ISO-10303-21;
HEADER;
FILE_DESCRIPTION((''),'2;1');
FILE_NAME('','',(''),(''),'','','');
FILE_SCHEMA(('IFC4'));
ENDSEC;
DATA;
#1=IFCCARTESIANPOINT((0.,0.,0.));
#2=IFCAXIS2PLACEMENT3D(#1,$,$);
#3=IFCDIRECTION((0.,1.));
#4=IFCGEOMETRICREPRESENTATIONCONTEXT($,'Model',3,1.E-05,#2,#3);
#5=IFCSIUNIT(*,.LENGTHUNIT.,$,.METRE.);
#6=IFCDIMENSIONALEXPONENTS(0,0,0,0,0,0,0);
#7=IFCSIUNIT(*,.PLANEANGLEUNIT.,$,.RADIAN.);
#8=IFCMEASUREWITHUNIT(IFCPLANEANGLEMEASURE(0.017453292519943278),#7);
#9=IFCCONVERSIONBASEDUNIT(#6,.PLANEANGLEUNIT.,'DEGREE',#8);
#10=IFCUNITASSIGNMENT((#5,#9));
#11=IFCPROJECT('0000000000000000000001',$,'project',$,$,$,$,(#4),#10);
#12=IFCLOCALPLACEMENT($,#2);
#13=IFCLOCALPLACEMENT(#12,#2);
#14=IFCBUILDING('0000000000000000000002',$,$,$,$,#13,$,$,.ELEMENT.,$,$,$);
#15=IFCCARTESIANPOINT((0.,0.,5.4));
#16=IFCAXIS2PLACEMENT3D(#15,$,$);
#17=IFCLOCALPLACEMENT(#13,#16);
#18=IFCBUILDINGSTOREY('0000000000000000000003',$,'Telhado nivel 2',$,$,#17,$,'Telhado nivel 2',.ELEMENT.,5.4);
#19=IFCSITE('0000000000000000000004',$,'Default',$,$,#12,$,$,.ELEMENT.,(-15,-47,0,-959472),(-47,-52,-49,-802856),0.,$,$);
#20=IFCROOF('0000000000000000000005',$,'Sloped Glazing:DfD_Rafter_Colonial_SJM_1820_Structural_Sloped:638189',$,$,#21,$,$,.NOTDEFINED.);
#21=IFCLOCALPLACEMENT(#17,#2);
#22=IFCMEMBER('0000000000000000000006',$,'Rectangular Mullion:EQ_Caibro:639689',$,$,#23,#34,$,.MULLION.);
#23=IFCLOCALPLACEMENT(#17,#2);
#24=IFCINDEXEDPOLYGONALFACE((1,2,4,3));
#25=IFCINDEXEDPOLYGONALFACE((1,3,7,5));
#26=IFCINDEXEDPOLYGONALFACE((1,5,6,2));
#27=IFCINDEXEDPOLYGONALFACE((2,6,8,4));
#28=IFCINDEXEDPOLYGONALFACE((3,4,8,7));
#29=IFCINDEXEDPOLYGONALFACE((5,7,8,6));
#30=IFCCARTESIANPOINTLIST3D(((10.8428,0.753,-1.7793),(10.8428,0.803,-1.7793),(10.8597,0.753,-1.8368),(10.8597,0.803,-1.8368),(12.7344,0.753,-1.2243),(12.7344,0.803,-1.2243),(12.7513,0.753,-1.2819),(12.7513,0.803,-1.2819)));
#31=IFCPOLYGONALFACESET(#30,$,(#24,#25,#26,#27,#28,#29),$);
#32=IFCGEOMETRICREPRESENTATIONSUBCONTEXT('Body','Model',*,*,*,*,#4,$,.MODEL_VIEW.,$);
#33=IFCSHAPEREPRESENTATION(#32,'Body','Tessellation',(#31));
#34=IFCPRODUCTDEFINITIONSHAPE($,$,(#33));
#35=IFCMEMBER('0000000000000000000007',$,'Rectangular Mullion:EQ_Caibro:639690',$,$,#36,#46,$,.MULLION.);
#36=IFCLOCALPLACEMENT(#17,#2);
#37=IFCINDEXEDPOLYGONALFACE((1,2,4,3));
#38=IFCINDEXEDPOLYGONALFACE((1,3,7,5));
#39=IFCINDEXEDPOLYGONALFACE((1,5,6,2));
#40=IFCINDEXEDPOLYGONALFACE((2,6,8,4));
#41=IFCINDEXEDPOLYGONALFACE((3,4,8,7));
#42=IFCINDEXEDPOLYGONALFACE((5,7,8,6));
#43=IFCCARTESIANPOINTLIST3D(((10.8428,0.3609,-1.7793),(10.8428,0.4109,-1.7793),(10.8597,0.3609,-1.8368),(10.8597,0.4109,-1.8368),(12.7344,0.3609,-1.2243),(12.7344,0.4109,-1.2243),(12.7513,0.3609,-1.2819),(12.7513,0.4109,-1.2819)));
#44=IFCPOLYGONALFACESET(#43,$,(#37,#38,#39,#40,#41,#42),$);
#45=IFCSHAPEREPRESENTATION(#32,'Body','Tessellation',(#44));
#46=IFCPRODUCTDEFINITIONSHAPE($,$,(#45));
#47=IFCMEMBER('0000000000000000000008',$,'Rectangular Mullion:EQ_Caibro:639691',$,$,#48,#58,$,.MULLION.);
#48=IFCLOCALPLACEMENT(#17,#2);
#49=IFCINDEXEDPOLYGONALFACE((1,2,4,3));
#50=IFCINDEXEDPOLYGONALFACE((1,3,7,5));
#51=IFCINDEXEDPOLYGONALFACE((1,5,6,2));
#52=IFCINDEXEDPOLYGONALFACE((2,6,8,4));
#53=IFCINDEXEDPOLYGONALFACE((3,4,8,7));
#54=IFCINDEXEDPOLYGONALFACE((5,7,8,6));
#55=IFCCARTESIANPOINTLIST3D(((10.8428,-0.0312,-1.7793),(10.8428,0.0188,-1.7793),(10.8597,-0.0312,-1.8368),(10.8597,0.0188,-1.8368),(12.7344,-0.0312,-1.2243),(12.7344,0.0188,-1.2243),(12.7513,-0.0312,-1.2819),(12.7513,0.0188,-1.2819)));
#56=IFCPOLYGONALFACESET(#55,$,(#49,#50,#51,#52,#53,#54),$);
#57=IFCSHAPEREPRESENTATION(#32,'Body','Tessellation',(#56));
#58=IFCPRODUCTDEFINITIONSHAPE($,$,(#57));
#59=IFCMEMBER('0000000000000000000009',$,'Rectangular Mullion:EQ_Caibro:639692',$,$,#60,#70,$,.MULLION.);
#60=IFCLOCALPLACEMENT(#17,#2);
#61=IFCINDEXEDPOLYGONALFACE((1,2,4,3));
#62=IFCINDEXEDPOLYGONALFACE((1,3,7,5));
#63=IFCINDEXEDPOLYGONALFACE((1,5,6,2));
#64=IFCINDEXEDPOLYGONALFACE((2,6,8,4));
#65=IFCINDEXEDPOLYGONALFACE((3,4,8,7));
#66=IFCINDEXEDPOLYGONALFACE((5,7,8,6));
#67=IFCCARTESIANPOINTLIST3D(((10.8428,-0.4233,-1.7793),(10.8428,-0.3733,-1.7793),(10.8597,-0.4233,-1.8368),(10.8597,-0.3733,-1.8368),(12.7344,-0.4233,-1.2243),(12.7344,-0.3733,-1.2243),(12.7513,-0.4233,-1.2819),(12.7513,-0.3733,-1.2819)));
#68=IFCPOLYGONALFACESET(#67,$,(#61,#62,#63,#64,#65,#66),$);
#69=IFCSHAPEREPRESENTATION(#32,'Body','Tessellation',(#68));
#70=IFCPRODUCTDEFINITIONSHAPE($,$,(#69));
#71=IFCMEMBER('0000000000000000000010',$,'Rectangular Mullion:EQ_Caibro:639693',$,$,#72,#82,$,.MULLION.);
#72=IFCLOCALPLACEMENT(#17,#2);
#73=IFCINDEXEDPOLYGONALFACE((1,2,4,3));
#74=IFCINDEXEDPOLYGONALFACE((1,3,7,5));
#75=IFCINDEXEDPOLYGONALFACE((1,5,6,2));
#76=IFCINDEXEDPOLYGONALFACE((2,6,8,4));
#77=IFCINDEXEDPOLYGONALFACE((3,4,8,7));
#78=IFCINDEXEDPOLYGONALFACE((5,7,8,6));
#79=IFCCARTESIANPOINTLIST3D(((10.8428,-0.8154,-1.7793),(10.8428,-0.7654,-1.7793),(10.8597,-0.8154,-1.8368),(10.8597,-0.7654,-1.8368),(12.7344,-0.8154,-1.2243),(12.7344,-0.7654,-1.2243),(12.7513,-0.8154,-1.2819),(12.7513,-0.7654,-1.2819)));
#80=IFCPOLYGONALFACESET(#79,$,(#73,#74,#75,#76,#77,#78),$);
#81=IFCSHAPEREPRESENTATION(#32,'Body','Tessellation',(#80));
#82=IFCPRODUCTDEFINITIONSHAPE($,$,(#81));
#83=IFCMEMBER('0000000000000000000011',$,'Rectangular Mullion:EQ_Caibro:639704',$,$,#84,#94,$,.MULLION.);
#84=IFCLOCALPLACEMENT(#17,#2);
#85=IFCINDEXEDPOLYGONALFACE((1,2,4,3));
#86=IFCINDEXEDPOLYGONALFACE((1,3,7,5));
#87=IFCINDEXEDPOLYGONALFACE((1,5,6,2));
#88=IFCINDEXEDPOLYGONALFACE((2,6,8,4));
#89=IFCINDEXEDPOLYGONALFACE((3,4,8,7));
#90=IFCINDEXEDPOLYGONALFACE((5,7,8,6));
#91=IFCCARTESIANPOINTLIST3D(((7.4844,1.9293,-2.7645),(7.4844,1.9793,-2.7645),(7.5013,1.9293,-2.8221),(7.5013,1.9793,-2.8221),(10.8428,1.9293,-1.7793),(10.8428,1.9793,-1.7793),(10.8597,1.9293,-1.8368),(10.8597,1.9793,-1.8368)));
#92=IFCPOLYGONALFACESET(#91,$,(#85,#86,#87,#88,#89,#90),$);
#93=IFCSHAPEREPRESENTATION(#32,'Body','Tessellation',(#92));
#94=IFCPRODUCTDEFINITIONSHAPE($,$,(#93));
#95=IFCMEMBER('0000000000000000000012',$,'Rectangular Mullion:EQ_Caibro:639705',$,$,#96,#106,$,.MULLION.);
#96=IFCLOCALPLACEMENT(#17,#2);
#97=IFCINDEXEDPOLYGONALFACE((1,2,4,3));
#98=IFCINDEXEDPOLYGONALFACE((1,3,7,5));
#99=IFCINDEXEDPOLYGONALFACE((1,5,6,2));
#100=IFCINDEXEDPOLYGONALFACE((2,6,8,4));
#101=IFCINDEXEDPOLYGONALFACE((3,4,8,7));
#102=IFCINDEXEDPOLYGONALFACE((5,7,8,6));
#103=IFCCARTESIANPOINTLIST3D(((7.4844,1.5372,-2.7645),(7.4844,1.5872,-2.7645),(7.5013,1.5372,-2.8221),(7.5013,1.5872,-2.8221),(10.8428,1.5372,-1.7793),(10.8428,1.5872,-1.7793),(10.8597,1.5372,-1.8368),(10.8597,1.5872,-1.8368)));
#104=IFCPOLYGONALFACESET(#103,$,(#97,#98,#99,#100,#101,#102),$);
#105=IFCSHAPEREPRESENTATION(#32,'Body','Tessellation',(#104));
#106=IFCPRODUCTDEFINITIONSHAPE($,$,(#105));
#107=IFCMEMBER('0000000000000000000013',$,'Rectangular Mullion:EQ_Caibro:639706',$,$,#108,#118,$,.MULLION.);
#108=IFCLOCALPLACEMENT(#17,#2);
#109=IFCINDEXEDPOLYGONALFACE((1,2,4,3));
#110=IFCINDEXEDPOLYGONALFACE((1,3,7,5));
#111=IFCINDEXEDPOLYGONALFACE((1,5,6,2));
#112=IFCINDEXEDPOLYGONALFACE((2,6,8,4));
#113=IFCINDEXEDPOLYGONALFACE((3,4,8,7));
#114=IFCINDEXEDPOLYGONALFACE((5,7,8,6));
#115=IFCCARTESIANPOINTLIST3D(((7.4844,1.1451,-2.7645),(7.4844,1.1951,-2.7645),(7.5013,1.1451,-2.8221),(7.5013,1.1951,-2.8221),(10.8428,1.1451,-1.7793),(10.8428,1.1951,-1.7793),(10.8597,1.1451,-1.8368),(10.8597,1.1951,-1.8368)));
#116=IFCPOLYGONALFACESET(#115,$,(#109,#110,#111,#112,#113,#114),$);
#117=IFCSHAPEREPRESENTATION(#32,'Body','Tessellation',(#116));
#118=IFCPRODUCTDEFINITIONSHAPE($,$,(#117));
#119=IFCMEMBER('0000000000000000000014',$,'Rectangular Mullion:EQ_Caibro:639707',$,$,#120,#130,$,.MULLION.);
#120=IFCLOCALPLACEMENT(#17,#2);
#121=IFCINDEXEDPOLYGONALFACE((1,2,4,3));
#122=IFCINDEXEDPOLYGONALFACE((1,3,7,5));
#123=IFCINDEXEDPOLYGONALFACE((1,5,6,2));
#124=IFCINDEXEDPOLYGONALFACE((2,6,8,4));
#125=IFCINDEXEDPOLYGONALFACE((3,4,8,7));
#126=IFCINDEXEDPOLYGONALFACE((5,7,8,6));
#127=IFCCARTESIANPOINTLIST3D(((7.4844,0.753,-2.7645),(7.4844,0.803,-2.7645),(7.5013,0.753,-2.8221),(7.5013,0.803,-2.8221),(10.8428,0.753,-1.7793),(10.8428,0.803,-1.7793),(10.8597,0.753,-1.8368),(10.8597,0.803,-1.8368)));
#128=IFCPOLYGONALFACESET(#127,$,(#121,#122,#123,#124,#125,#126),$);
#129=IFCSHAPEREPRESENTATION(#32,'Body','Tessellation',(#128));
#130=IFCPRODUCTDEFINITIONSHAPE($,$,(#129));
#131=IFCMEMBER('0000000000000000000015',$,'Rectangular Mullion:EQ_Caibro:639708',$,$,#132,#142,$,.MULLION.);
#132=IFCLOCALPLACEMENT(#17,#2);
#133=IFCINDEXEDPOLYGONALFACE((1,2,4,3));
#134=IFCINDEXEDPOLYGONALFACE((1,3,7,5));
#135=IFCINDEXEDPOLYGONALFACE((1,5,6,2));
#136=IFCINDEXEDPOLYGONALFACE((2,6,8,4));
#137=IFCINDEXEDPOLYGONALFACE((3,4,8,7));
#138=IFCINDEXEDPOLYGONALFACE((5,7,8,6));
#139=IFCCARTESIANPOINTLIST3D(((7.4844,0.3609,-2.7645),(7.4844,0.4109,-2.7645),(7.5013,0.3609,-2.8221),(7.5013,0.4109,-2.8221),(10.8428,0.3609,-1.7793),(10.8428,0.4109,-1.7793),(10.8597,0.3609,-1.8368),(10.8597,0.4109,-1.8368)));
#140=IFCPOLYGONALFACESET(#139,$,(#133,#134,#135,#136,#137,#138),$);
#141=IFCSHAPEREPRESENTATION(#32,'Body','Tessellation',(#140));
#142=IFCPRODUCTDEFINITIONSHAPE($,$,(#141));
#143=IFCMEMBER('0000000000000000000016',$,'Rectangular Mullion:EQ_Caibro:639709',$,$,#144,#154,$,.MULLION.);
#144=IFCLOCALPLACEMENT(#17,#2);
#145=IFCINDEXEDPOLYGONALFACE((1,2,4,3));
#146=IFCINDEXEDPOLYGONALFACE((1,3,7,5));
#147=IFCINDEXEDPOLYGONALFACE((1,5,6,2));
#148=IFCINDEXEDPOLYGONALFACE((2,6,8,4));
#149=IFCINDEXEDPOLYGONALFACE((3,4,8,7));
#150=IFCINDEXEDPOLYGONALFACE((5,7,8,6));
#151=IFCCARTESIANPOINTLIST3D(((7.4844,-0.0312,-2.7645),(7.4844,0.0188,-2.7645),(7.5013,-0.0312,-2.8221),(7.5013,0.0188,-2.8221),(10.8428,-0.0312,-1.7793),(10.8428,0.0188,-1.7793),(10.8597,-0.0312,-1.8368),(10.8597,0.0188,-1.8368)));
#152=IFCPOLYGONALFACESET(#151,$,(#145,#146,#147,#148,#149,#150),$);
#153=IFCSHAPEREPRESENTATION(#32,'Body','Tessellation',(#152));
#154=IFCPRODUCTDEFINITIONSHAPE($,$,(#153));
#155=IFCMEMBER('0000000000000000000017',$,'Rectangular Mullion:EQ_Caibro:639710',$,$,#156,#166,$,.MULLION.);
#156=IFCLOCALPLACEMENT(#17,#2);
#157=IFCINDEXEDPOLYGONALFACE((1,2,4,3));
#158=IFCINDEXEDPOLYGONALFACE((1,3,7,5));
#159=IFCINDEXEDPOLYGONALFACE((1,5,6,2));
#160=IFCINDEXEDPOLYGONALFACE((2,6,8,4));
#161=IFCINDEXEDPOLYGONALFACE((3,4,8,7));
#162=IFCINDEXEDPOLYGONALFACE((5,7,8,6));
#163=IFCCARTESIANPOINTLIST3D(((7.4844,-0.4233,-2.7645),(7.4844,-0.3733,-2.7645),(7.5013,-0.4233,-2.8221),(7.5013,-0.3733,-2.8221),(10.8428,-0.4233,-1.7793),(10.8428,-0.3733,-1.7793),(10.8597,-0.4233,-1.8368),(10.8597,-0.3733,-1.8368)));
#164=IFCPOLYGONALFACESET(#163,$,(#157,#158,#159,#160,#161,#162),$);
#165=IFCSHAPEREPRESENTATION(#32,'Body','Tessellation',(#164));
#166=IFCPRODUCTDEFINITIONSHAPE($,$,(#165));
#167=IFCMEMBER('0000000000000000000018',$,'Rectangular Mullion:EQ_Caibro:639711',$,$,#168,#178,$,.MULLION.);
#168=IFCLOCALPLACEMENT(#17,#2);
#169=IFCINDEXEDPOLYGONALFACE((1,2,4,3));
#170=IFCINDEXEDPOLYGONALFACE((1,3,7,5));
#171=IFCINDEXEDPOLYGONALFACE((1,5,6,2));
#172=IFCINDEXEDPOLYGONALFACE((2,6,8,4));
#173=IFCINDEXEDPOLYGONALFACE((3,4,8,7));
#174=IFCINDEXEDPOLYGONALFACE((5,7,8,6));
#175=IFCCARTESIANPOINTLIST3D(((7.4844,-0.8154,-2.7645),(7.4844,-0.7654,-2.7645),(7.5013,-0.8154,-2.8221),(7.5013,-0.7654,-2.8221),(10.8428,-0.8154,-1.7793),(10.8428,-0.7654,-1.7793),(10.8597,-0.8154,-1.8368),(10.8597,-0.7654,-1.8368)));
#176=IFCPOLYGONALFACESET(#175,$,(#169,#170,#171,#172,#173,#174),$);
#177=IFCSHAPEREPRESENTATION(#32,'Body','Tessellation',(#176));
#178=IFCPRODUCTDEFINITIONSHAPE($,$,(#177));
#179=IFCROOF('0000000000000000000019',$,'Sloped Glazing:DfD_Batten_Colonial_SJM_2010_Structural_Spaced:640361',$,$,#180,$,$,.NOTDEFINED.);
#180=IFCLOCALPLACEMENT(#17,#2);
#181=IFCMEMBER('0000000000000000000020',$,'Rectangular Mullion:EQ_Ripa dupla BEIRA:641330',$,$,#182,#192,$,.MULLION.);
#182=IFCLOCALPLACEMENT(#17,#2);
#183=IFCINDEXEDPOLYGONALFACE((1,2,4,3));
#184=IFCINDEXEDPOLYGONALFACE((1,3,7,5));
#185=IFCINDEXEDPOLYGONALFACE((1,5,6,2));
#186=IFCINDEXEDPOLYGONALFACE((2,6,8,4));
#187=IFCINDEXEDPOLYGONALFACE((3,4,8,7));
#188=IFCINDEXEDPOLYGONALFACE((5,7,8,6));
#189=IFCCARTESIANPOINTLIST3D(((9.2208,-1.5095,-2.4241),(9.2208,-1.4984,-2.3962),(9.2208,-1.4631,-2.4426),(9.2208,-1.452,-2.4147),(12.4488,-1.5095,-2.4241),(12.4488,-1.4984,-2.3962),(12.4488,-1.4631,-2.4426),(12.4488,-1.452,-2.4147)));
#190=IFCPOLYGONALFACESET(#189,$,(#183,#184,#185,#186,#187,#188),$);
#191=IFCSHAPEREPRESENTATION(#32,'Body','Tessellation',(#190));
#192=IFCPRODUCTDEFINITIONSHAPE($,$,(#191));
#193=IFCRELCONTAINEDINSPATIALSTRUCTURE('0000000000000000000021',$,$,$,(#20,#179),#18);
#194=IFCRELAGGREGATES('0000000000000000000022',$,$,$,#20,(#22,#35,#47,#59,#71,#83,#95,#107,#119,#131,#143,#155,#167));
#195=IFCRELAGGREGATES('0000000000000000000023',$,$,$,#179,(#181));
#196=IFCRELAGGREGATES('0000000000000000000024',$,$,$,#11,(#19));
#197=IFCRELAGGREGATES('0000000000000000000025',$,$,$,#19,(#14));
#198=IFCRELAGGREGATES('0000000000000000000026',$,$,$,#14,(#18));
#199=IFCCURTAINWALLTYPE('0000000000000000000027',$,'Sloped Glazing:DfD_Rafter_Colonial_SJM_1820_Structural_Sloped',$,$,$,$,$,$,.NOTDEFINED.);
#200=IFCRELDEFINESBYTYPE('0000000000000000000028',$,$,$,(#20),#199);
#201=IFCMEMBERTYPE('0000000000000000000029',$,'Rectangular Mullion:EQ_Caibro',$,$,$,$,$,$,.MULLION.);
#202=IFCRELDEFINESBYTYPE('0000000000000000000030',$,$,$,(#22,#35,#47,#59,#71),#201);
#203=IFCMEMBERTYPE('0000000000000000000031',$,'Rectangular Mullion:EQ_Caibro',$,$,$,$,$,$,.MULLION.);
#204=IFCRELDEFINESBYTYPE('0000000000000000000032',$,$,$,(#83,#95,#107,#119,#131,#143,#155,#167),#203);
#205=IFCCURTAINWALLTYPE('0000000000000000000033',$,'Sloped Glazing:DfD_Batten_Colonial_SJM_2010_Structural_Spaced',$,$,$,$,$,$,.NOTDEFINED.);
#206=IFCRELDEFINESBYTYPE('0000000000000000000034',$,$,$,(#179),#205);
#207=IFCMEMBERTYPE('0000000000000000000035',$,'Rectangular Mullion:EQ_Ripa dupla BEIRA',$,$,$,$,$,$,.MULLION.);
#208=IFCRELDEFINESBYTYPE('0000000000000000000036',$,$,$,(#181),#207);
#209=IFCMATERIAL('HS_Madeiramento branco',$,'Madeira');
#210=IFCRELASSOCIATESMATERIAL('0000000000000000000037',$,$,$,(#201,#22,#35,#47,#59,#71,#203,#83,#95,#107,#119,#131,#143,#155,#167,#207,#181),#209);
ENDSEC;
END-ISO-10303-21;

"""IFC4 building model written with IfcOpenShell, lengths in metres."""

from ifc_helpers import new_model, entity, si_unit, converted_unit, direction, frame, origin, place, context, subcontext, project, spatial, indexed_curve, outline, extrude, source, transform, mapped, material, type_object, type_shapes, element, aggregate, save


model = new_model("IFC4")

# Units and contexts
model_context = context("Model", 3, precision=1e-05, world=origin(), true_north=direction((0.0, 1.0)))
body_context = subcontext(model_context, "Body", "Model", "MODEL_VIEW")
ifc_project = project(units=[si_unit("LENGTHUNIT", "METRE"), converted_unit("PLANEANGLEUNIT", "DEGREE", entity("IfcPlaneAngleMeasure", 0.017453292519943278), si_unit("PLANEANGLEUNIT", "RADIAN"), dimensions=[0, 0, 0, 0, 0, 0, 0])], contexts=[model_context])

# Site, building, storey
site_placement = place(None, origin())
site = spatial("IfcSite", under=ifc_project, at=site_placement, Name="Default", CompositionType="ELEMENT", RefLatitude=(-15, -47, 0, -959472), RefLongitude=(-47, -52, -49, -802856), RefElevation=0.0)
building_placement = place(site_placement, origin())
building = spatial("IfcBuilding", under=site, at=building_placement, CompositionType="ELEMENT")
storey_placement = place(building_placement, frame((0.0, 0.0, 5.4)))
storey = spatial("IfcBuildingStorey", under=building, at=storey_placement, Name="Telhado nivel 2", LongName="Telhado nivel 2", CompositionType="ELEMENT", Elevation=5.4)

# Roofs, members
curtain_wall_type_1 = type_object("IfcCurtainWallType", Name="Sloped Glazing:DfD_Rafter_Colonial_SJM_1820_Structural_Sloped", PredefinedType="NOTDEFINED")
ifc_material = material(Name="HS_Madeiramento branco", Category="Madeira")
roof_1_placement = place(storey_placement, frame((0.0, 0.0, -5.4)))
roof_1 = element("IfcRoof", 1, at=roof_1_placement, inside=storey, type_object=curtain_wall_type_1, Name="Sloped Glazing:DfD_Rafter_Colonial_SJM_1820_Structural_Sloped:638189", PredefinedType="NOTDEFINED")
member_type_1 = type_object("IfcMemberType", Name="Rectangular Mullion:EQ_Caibro", PredefinedType="MULLION", material=ifc_material)
shared_shape_1 = source(origin(), body_context, "Body", "SweptSolid", [
    extrude(outline(indexed_curve([(-0.025, -0.03), (0.025, -0.03), (0.025, 0.03), (-0.025, 0.03), (-0.025, -0.03)], self_intersect=False)), frame((0.0, -0.03, -1.9713), z_axis=(0.0, 0.0, 1.0), x_axis=(-1.0, 0.0, 0.0)), (0.0, 0.0, 1.0), 1.9713),
])
type_shapes(member_type_1, [shared_shape_1])
member_1_placement = place(roof_1_placement, frame((12.7513, 0.778, 4.1181), z_axis=(0.95956, 0.0, 0.281504), x_axis=(0.0, -1.0, 0.0)))
member_1 = element("IfcMember", 2, at=member_1_placement, type_object=member_type_1, material=ifc_material, Name="Rectangular Mullion:EQ_Caibro:639689", PredefinedType="MULLION", context=body_context, shape_type="MappedRepresentation", body=[
    mapped(shared_shape_1, transform((0.0, 0.0, 0.0), scale=1.0)),
])
member_2_placement = place(roof_1_placement, frame((12.7513, 0.3859, 4.1181), z_axis=(0.95956, 0.0, 0.281504), x_axis=(0.0, -1.0, 0.0)))
member_2 = element("IfcMember", 3, at=member_2_placement, type_object=member_type_1, material=ifc_material, Name="Rectangular Mullion:EQ_Caibro:639690", PredefinedType="MULLION", context=body_context, shape_type="MappedRepresentation", body=[
    mapped(shared_shape_1, transform((0.0, 0.0, 0.0), scale=1.0)),
])
member_3_placement = place(roof_1_placement, frame((12.7513, -0.0062, 4.1181), z_axis=(0.95956, 0.0, 0.281504), x_axis=(0.0, -1.0, 0.0)))
member_3 = element("IfcMember", 4, at=member_3_placement, type_object=member_type_1, material=ifc_material, Name="Rectangular Mullion:EQ_Caibro:639691", PredefinedType="MULLION", context=body_context, shape_type="MappedRepresentation", body=[
    mapped(shared_shape_1, transform((0.0, 0.0, 0.0), scale=1.0)),
])
member_4_placement = place(roof_1_placement, frame((12.7513, -0.3983, 4.1181), z_axis=(0.95956, 0.0, 0.281504), x_axis=(0.0, -1.0, 0.0)))
member_4 = element("IfcMember", 5, at=member_4_placement, type_object=member_type_1, material=ifc_material, Name="Rectangular Mullion:EQ_Caibro:639692", PredefinedType="MULLION", context=body_context, shape_type="MappedRepresentation", body=[
    mapped(shared_shape_1, transform((0.0, 0.0, 0.0), scale=1.0)),
])
member_5_placement = place(roof_1_placement, frame((12.7513, -0.7904, 4.1181), z_axis=(0.95956, 0.0, 0.281504), x_axis=(0.0, -1.0, 0.0)))
member_5 = element("IfcMember", 6, at=member_5_placement, type_object=member_type_1, material=ifc_material, Name="Rectangular Mullion:EQ_Caibro:639693", PredefinedType="MULLION", context=body_context, shape_type="MappedRepresentation", body=[
    mapped(shared_shape_1, transform((0.0, 0.0, 0.0), scale=1.0)),
])
member_type_2 = type_object("IfcMemberType", Name="Rectangular Mullion:EQ_Caibro", PredefinedType="MULLION", material=ifc_material)
shared_shape_2 = source(origin(), body_context, "Body", "SweptSolid", [
    extrude(outline(indexed_curve([(-0.025, -0.03), (0.025, -0.03), (0.025, 0.03), (-0.025, 0.03), (-0.025, -0.03)], self_intersect=False)), frame((0.0, -0.03, -3.5), z_axis=(0.0, 0.0, 1.0), x_axis=(-1.0, 0.0, 0.0)), (0.0, 0.0, 1.0), 3.5),
])
type_shapes(member_type_2, [shared_shape_2])
member_6_placement = place(roof_1_placement, frame((10.8597, 1.9543, 3.5632), z_axis=(0.95956, 0.0, 0.281504), x_axis=(0.0, -1.0, 0.0)))
member_6 = element("IfcMember", 7, at=member_6_placement, type_object=member_type_2, material=ifc_material, Name="Rectangular Mullion:EQ_Caibro:639704", PredefinedType="MULLION", context=body_context, shape_type="MappedRepresentation", body=[
    mapped(shared_shape_2, transform((0.0, 0.0, 0.0), scale=1.0)),
])
member_7_placement = place(roof_1_placement, frame((10.8597, 1.5622, 3.5632), z_axis=(0.95956, 0.0, 0.281504), x_axis=(0.0, -1.0, 0.0)))
member_7 = element("IfcMember", 8, at=member_7_placement, type_object=member_type_2, material=ifc_material, Name="Rectangular Mullion:EQ_Caibro:639705", PredefinedType="MULLION", context=body_context, shape_type="MappedRepresentation", body=[
    mapped(shared_shape_2, transform((0.0, 0.0, 0.0), scale=1.0)),
])
member_8_placement = place(roof_1_placement, frame((10.8597, 1.1701, 3.5632), z_axis=(0.95956, 0.0, 0.281504), x_axis=(0.0, -1.0, 0.0)))
member_8 = element("IfcMember", 9, at=member_8_placement, type_object=member_type_2, material=ifc_material, Name="Rectangular Mullion:EQ_Caibro:639706", PredefinedType="MULLION", context=body_context, shape_type="MappedRepresentation", body=[
    mapped(shared_shape_2, transform((0.0, 0.0, 0.0), scale=1.0)),
])
member_9_placement = place(roof_1_placement, frame((10.8597, 0.778, 3.5632), z_axis=(0.95956, 0.0, 0.281504), x_axis=(0.0, -1.0, 0.0)))
member_9 = element("IfcMember", 10, at=member_9_placement, type_object=member_type_2, material=ifc_material, Name="Rectangular Mullion:EQ_Caibro:639707", PredefinedType="MULLION", context=body_context, shape_type="MappedRepresentation", body=[
    mapped(shared_shape_2, transform((0.0, 0.0, 0.0), scale=1.0)),
])
member_10_placement = place(roof_1_placement, frame((10.8597, 0.3859, 3.5632), z_axis=(0.95956, 0.0, 0.281504), x_axis=(0.0, -1.0, 0.0)))
member_10 = element("IfcMember", 11, at=member_10_placement, type_object=member_type_2, material=ifc_material, Name="Rectangular Mullion:EQ_Caibro:639708", PredefinedType="MULLION", context=body_context, shape_type="MappedRepresentation", body=[
    mapped(shared_shape_2, transform((0.0, 0.0, 0.0), scale=1.0)),
])
member_11_placement = place(roof_1_placement, frame((10.8597, -0.0062, 3.5632), z_axis=(0.95956, 0.0, 0.281504), x_axis=(0.0, -1.0, 0.0)))
member_11 = element("IfcMember", 12, at=member_11_placement, type_object=member_type_2, material=ifc_material, Name="Rectangular Mullion:EQ_Caibro:639709", PredefinedType="MULLION", context=body_context, shape_type="MappedRepresentation", body=[
    mapped(shared_shape_2, transform((0.0, 0.0, 0.0), scale=1.0)),
])
member_12_placement = place(roof_1_placement, frame((10.8597, -0.3983, 3.5632), z_axis=(0.95956, 0.0, 0.281504), x_axis=(0.0, -1.0, 0.0)))
member_12 = element("IfcMember", 13, at=member_12_placement, type_object=member_type_2, material=ifc_material, Name="Rectangular Mullion:EQ_Caibro:639710", PredefinedType="MULLION", context=body_context, shape_type="MappedRepresentation", body=[
    mapped(shared_shape_2, transform((0.0, 0.0, 0.0), scale=1.0)),
])
member_13_placement = place(roof_1_placement, frame((10.8597, -0.7904, 3.5632), z_axis=(0.95956, 0.0, 0.281504), x_axis=(0.0, -1.0, 0.0)))
member_13 = element("IfcMember", 14, at=member_13_placement, type_object=member_type_2, material=ifc_material, Name="Rectangular Mullion:EQ_Caibro:639711", PredefinedType="MULLION", context=body_context, shape_type="MappedRepresentation", body=[
    mapped(shared_shape_2, transform((0.0, 0.0, 0.0), scale=1.0)),
])
aggregate(roof_1, [member_1, member_2, member_3, member_4, member_5, member_6, member_7, member_8, member_9, member_10, member_11, member_12, member_13])
curtain_wall_type_2 = type_object("IfcCurtainWallType", Name="Sloped Glazing:DfD_Batten_Colonial_SJM_2010_Structural_Spaced", PredefinedType="NOTDEFINED")
roof_2_placement = place(storey_placement, frame((0.0, 0.0, -5.4)))
roof_2 = element("IfcRoof", 15, at=roof_2_placement, inside=storey, type_object=curtain_wall_type_2, Name="Sloped Glazing:DfD_Batten_Colonial_SJM_2010_Structural_Spaced:640361", PredefinedType="NOTDEFINED")
member_type_3 = type_object("IfcMemberType", Name="Rectangular Mullion:EQ_Ripa dupla BEIRA", PredefinedType="MULLION", material=ifc_material)
shared_shape_3 = source(origin(), body_context, "Body", "SweptSolid", [
    extrude(outline(indexed_curve([(-0.025, -0.015), (0.025, -0.015), (0.025, 0.015), (-0.025, 0.015), (-0.025, -0.015)], self_intersect=False)), frame((-0.025, 0.0, -3.228), z_axis=(0.0, 0.0, 1.0), x_axis=(-1.0, 0.0, 0.0)), (0.0, 0.0, 1.0), 3.228),
])
type_shapes(member_type_3, [shared_shape_3])
member_14_placement = place(roof_2_placement, frame((9.2208, -1.4575, 2.9713), z_axis=(-1.0, 0.0, 0.0), x_axis=(0.0, 0.928874, -0.370395)))
member_14 = element("IfcMember", 16, at=member_14_placement, type_object=member_type_3, material=ifc_material, Name="Rectangular Mullion:EQ_Ripa dupla BEIRA:641330", PredefinedType="MULLION", context=body_context, shape_type="MappedRepresentation", body=[
    mapped(shared_shape_3, transform((0.0, 0.0, 0.0), scale=1.0)),
])
aggregate(roof_2, [member_14])

save(model, "model.ifc")
